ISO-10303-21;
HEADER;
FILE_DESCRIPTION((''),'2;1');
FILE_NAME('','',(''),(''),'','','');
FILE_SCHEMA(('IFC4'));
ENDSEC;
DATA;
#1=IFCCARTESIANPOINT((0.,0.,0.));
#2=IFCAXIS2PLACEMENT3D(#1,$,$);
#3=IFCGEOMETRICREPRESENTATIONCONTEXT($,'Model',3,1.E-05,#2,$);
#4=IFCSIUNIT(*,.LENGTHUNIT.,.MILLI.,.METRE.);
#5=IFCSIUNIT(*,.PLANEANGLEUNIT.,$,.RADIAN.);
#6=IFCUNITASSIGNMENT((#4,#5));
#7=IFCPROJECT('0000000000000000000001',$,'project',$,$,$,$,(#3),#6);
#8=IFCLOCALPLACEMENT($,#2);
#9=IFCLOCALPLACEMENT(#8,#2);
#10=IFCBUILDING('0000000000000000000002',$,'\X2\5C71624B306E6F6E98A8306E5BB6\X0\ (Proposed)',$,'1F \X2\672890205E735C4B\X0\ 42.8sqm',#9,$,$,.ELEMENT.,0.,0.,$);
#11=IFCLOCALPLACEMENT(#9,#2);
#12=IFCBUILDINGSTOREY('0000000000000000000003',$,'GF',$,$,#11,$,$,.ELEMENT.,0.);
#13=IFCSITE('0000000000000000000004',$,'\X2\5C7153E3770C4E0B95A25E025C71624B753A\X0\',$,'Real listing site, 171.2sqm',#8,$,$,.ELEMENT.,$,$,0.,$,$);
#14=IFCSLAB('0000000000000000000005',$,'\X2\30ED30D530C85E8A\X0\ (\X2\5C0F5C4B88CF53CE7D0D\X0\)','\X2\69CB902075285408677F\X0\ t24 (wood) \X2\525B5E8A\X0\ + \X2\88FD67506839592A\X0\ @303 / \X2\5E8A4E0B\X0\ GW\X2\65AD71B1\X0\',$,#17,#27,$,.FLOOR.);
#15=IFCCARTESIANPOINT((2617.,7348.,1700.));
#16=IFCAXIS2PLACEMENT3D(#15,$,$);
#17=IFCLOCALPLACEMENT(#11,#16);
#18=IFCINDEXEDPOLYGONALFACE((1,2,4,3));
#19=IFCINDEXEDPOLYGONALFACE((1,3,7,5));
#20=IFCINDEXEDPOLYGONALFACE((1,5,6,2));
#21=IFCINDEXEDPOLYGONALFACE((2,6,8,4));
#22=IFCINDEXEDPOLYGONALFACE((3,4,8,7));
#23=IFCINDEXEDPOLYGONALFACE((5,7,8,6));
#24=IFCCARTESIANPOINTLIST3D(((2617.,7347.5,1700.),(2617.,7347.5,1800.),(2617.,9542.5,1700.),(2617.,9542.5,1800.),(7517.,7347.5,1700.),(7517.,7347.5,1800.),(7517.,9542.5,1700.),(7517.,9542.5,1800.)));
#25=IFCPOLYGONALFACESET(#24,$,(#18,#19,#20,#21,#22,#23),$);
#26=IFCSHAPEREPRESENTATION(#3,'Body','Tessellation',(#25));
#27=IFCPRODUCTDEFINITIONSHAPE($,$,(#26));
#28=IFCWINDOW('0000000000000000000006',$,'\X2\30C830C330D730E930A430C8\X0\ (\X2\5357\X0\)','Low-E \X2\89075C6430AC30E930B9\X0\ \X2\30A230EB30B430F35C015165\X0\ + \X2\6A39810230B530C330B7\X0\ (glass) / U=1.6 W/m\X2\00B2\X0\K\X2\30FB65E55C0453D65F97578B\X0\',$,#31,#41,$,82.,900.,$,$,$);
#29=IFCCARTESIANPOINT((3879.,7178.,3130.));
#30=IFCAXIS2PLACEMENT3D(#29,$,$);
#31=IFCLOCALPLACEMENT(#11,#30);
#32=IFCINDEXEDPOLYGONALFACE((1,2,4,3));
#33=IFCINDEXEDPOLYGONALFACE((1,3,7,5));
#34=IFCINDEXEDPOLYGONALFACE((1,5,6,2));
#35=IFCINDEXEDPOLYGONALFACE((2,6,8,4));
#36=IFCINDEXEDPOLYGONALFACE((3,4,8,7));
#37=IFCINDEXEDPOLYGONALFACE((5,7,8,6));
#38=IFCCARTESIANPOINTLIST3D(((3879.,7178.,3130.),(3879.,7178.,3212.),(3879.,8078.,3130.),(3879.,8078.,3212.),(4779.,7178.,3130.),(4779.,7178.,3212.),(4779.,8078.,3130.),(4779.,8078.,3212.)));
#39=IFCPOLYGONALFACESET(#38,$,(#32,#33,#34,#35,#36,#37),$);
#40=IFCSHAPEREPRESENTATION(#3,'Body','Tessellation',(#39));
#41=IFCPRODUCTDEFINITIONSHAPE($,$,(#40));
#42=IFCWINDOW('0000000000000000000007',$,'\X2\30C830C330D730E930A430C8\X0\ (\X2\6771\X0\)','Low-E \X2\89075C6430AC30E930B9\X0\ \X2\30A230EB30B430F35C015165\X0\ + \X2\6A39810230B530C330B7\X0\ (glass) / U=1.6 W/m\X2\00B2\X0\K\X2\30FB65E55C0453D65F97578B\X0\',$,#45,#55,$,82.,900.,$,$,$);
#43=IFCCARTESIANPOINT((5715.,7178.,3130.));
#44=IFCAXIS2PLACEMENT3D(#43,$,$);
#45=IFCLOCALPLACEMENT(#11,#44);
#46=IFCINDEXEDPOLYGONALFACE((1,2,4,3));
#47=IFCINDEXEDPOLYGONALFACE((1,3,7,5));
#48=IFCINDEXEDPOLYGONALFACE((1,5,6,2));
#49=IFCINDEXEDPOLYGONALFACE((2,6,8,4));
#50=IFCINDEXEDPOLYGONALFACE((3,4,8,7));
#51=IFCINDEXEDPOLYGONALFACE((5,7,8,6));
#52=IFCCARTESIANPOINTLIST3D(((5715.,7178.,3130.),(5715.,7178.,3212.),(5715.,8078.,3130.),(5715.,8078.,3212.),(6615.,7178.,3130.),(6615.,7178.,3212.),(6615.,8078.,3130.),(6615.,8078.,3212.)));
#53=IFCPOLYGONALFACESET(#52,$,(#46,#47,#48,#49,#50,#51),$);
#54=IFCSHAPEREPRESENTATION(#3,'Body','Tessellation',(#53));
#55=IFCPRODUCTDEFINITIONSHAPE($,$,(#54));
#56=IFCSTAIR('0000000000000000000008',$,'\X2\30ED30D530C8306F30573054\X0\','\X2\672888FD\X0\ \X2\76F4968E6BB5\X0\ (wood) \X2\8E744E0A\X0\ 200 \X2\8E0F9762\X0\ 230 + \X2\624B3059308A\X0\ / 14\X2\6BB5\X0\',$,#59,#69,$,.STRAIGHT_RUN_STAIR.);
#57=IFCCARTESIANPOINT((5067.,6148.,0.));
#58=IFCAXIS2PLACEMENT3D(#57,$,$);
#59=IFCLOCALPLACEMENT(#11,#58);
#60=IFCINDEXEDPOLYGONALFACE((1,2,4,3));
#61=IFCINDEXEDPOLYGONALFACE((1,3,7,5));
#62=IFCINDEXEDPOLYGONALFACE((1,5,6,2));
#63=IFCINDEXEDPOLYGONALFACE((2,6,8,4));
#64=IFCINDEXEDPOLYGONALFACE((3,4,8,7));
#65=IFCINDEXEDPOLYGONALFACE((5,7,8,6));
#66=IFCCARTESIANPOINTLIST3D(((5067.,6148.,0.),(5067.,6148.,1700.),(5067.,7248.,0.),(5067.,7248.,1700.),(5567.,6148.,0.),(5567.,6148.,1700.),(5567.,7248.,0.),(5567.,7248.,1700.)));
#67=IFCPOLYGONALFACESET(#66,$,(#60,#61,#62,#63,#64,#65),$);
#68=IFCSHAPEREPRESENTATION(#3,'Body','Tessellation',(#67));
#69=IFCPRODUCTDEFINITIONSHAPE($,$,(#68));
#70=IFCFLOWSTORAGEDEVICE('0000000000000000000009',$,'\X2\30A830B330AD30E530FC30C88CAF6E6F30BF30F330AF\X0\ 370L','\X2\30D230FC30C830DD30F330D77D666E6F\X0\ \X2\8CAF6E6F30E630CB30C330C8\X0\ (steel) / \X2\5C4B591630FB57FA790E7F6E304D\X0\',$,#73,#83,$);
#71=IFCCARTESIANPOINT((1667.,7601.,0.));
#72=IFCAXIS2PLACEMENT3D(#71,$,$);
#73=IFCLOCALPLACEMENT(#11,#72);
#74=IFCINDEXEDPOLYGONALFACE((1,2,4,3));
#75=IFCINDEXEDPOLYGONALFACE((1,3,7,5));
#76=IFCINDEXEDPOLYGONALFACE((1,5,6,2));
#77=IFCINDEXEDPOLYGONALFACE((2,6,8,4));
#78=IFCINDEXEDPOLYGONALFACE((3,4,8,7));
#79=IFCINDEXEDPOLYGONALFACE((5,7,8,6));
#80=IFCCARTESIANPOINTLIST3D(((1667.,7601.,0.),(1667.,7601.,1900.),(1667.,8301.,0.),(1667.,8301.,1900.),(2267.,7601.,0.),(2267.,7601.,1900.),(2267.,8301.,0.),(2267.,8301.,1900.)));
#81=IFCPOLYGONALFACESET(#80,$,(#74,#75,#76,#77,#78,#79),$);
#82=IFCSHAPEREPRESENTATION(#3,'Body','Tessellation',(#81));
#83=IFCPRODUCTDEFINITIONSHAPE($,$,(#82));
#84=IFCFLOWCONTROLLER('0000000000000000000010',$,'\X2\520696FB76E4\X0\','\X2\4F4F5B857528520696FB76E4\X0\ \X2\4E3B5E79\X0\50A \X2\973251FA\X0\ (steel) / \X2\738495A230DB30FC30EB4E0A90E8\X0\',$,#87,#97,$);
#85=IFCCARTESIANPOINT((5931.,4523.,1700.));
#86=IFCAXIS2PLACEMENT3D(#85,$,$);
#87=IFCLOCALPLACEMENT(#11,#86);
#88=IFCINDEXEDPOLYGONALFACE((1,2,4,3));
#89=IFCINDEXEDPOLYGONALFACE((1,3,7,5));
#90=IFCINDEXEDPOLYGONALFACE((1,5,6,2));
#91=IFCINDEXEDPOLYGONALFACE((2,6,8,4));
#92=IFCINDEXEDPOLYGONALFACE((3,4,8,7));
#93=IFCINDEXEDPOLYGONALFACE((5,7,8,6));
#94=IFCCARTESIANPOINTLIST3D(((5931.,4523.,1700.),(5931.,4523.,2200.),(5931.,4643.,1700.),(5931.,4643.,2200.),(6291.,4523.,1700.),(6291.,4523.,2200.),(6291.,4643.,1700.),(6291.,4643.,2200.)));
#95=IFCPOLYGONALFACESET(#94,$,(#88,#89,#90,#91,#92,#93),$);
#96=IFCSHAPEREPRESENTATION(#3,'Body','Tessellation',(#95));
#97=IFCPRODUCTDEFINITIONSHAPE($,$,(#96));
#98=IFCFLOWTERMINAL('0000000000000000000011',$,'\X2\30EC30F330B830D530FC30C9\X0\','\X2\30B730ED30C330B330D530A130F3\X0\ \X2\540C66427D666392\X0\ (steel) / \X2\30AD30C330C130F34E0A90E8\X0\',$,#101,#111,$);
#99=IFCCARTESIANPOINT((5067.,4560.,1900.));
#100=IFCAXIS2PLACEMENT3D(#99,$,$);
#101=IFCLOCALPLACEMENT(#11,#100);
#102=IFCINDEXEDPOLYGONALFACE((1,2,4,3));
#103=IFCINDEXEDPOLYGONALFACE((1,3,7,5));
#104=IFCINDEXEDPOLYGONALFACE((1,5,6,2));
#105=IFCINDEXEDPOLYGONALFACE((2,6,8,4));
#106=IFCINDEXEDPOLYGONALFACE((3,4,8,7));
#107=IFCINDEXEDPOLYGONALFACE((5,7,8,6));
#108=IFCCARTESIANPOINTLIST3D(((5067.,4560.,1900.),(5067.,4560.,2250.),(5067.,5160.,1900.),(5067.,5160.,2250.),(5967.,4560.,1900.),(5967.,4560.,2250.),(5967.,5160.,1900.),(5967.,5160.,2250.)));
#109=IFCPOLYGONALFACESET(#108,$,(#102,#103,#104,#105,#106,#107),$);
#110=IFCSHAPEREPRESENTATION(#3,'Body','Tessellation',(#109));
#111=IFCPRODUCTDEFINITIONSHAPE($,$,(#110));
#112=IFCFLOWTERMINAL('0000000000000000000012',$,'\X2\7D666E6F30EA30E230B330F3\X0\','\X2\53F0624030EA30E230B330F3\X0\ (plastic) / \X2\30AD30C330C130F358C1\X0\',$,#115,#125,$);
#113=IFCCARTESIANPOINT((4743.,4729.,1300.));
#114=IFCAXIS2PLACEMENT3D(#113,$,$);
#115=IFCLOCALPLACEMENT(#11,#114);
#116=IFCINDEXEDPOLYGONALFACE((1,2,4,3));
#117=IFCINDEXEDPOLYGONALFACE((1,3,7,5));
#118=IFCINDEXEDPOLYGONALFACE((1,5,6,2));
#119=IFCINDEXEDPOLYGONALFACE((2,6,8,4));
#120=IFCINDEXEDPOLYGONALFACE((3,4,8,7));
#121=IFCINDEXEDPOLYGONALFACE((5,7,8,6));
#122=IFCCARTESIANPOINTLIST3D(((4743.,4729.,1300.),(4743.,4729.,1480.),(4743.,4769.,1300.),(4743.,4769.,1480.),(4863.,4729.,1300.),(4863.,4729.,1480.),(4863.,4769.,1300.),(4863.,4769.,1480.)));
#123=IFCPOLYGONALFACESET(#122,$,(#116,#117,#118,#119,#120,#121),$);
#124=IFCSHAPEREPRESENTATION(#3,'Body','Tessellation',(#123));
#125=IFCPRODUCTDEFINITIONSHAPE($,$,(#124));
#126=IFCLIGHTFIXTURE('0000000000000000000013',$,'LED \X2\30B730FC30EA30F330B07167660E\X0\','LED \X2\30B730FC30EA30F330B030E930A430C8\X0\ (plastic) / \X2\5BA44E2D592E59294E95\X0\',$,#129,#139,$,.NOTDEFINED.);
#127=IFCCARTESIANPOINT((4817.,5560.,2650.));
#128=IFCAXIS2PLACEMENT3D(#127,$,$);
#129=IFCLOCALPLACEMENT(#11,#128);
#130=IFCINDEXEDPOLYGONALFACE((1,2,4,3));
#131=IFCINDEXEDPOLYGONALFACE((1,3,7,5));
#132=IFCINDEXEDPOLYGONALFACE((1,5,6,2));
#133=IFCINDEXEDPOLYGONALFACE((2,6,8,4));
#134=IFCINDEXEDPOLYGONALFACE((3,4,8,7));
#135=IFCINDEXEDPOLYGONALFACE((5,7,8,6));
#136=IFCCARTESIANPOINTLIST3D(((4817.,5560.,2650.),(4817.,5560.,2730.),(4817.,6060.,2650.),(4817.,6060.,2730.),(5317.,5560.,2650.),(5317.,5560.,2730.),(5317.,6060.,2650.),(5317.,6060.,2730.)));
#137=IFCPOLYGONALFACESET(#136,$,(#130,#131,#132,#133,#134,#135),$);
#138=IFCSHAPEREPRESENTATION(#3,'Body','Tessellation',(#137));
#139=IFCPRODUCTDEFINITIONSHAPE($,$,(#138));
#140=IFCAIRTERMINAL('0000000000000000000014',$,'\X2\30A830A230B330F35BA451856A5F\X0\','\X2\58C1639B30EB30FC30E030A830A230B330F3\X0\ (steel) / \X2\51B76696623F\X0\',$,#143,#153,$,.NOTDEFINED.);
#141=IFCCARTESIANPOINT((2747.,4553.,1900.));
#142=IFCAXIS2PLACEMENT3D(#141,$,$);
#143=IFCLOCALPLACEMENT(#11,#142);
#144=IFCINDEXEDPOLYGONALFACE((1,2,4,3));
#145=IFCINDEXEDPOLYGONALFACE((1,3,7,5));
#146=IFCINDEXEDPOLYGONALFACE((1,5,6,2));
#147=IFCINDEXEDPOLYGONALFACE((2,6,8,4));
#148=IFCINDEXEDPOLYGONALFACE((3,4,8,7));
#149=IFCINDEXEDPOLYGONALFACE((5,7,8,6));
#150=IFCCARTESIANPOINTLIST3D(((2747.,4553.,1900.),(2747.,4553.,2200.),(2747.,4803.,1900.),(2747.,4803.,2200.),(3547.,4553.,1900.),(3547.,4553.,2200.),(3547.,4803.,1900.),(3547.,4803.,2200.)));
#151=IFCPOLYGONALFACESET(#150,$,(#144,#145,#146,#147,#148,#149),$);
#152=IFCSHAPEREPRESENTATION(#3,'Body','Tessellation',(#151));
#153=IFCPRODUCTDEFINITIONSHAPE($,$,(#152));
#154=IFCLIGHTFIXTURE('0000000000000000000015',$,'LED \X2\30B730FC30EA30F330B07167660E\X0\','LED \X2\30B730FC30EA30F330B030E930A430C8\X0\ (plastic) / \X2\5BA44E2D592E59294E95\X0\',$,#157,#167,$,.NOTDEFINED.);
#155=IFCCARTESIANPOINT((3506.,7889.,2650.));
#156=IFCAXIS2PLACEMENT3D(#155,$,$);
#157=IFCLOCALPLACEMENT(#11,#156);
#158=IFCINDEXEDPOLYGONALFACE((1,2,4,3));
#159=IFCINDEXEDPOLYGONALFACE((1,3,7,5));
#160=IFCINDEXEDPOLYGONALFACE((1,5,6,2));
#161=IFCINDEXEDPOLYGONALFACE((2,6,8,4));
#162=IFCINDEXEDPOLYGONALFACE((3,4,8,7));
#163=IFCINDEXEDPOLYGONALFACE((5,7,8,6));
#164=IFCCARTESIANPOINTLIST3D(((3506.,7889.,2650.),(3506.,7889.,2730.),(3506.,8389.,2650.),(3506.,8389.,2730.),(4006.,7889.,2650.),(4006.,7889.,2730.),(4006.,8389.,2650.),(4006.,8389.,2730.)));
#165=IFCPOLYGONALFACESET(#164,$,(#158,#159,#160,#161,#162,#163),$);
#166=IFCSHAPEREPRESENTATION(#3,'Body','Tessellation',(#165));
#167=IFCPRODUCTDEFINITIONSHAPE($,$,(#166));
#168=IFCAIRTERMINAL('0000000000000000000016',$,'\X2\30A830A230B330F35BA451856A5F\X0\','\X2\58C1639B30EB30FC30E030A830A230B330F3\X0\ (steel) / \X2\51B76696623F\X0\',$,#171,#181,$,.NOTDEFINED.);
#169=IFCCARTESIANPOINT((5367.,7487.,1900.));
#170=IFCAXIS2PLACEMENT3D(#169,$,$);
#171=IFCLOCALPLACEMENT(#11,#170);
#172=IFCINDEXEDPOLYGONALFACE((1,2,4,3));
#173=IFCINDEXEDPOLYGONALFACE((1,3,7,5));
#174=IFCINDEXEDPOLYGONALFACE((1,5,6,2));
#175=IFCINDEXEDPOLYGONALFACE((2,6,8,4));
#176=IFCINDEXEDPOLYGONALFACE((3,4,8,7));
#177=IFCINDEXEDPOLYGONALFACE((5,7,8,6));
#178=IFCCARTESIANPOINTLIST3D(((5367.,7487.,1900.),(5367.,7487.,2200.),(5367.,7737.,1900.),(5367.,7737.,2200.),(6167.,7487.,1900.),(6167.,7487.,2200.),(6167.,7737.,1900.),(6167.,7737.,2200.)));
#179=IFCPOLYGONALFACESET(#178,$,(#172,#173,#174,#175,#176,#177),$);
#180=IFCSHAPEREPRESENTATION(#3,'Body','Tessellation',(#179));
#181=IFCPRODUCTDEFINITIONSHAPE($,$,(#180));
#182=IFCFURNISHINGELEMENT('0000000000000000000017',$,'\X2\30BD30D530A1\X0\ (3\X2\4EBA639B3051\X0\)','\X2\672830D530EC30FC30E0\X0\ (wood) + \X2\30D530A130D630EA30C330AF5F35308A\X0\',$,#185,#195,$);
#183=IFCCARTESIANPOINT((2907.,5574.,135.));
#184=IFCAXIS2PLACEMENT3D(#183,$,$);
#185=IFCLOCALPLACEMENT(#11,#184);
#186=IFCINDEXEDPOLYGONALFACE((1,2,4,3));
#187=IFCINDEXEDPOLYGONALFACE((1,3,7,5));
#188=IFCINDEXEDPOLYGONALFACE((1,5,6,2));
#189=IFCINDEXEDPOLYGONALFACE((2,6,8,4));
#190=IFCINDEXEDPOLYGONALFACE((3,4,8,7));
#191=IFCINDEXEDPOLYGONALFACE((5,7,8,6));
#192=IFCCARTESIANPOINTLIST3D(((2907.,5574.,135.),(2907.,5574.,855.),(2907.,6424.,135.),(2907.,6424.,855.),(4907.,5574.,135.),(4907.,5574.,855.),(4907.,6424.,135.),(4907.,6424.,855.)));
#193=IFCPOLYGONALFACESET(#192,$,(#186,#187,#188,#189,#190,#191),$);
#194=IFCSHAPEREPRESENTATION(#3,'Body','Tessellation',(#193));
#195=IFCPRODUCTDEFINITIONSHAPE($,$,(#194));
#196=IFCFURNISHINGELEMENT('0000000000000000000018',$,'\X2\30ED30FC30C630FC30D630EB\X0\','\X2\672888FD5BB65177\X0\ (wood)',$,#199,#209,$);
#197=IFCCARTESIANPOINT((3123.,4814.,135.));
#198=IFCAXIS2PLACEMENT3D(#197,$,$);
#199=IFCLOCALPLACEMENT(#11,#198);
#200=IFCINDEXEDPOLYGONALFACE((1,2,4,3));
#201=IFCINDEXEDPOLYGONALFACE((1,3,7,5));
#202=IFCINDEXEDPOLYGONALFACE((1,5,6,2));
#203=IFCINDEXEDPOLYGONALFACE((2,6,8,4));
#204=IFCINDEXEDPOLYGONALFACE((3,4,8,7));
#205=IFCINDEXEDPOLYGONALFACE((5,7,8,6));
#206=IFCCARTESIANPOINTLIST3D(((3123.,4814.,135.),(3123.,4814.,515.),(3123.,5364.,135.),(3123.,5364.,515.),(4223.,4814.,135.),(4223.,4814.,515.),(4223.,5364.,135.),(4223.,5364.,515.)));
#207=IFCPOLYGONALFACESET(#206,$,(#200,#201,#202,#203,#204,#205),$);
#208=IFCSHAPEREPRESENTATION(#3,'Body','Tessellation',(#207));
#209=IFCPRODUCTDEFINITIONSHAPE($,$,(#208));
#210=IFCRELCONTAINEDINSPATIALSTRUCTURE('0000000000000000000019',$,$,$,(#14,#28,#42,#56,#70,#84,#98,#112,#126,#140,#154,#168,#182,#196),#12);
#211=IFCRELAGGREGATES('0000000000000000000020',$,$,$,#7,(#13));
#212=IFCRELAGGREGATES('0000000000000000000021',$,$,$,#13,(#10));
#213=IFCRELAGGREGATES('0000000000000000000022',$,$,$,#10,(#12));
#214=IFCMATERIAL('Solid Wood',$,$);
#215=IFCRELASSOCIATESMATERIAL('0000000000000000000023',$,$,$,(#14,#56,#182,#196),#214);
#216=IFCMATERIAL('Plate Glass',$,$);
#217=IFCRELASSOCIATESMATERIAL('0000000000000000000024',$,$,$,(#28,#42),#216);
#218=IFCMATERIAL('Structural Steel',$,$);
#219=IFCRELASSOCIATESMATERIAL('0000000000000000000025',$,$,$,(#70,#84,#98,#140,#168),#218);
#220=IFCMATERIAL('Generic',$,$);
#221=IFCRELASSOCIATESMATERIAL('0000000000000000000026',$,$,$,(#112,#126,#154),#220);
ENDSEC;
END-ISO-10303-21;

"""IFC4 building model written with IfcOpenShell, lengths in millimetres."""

from ifc_helpers import new_model, si_unit, frame, frame_2d, origin, place, context, project, spatial, rectangle, extrude, material, element, save


model = new_model("IFC4")

# Units and contexts
model_context = context("Model", 3, precision=1e-05, world=origin())
ifc_project = project(units=[si_unit("LENGTHUNIT", "METRE", prefix="MILLI"), si_unit("PLANEANGLEUNIT", "RADIAN")], contexts=[model_context])

# Site, building, storey
site_placement = place(None, origin())
site = spatial("IfcSite", under=ifc_project, at=site_placement, Name="山口県下関市山手町", ObjectType="Real listing site, 171.2sqm", CompositionType="ELEMENT", RefElevation=0.0)
building_placement = place(site_placement, origin())
building = spatial("IfcBuilding", under=site, at=building_placement, Name="山手の潮風の家 (Proposed)", ObjectType="1F 木造平屋 42.8sqm", CompositionType="ELEMENT", ElevationOfRefHeight=0.0, ElevationOfTerrain=0.0)
storey_placement = place(building_placement, origin())
storey = spatial("IfcBuildingStorey", under=building, at=storey_placement, Name="GF", CompositionType="ELEMENT", Elevation=0.0)

# Shared definitions
ifc_material_1 = material(Name="Solid Wood")

# Slab
slab_placement = place(storey_placement, frame((2617.0, 7348.0, 1700.0)))
element("IfcSlab", 1, at=slab_placement, inside=storey, material=ifc_material_1, Name="ロフト床 (小屋裏収納)", Description="構造用合板 t24 (wood) 剛床 + 製材根太 @303 / 床下 GW断熱", PredefinedType="FLOOR", context=model_context, shape_type="SweptSolid", body=[
    extrude(rectangle(XDim=4900.0, YDim=2195.0, at=frame_2d((2450.0, 1097.0))), frame((2617.0, 7348.0, 1700.0)), (0.0, 0.0, 1.0), 100.0),
])

# Windows
ifc_material_2 = material(Name="Plate Glass")
window_1_placement = place(storey_placement, frame((3879.0, 7178.0, 3130.0)))
element("IfcWindow", 2, at=window_1_placement, inside=storey, material=ifc_material_2, Name="トップライト (南)", Description="Low-E 複層ガラス アルゴン封入 + 樹脂サッシ (glass) / U=1.6 W/m²K・日射取得型", OverallHeight=82.0, OverallWidth=900.0, context=model_context, shape_type="SweptSolid", body=[
    extrude(rectangle(XDim=900.0, YDim=900.0, at=frame_2d((450.0, 450.0))), frame((3879.0, 7178.0, 3130.0)), (0.0, 0.0, 1.0), 82.0),
])
window_2_placement = place(storey_placement, frame((5715.0, 7178.0, 3130.0)))
element("IfcWindow", 3, at=window_2_placement, inside=storey, material=ifc_material_2, Name="トップライト (東)", Description="Low-E 複層ガラス アルゴン封入 + 樹脂サッシ (glass) / U=1.6 W/m²K・日射取得型", OverallHeight=82.0, OverallWidth=900.0, context=model_context, shape_type="SweptSolid", body=[
    extrude(rectangle(XDim=900.0, YDim=900.0, at=frame_2d((450.0, 450.0))), frame((5715.0, 7178.0, 3130.0)), (0.0, 0.0, 1.0), 82.0),
])

# Stair
stair_placement = place(storey_placement, frame((5067.0, 6148.0, 0.0)))
element("IfcStair", 4, at=stair_placement, inside=storey, material=ifc_material_1, Name="ロフトはしご", Description="木製 直階段 (wood) 蹴上 200 踏面 230 + 手すり / 14段", PredefinedType="STRAIGHT_RUN_STAIR", context=model_context, shape_type="SweptSolid", body=[
    extrude(rectangle(XDim=500.0, YDim=1100.0, at=frame_2d((250.0, 550.0))), frame((5067.0, 6148.0, 0.0)), (0.0, 0.0, 1.0), 1700.0),
])

# Flow storage device
ifc_material_3 = material(Name="Structural Steel")
flow_storage_device_placement = place(storey_placement, frame((1667.0, 7601.0, 0.0)))
element("IfcFlowStorageDevice", 5, at=flow_storage_device_placement, inside=storey, material=ifc_material_3, Name="エコキュート貯湯タンク 370L", Description="ヒートポンプ給湯 貯湯ユニット (steel) / 屋外・基礎置き", context=model_context, shape_type="SweptSolid", body=[
    extrude(rectangle(XDim=600.0, YDim=700.0, at=frame_2d((300.0, 350.0))), frame((1667.0, 7601.0, 0.0)), (0.0, 0.0, 1.0), 1900.0),
])

# Flow controller
flow_controller_placement = place(storey_placement, frame((5931.0, 4523.0, 1700.0)))
element("IfcFlowController", 6, at=flow_controller_placement, inside=storey, material=ifc_material_3, Name="分電盤", Description="住宅用分電盤 主幹50A 露出 (steel) / 玄関ホール上部", context=model_context, shape_type="SweptSolid", body=[
    extrude(rectangle(XDim=360.0, YDim=120.0, at=frame_2d((180.0, 60.0))), frame((5931.0, 4523.0, 1700.0)), (0.0, 0.0, 1.0), 500.0),
])

# Flow terminals
flow_terminal_1_placement = place(storey_placement, frame((5067.0, 4560.0, 1900.0)))
element("IfcFlowTerminal", 7, at=flow_terminal_1_placement, inside=storey, material=ifc_material_3, Name="レンジフード", Description="シロッコファン 同時給排 (steel) / キッチン上部", context=model_context, shape_type="SweptSolid", body=[
    extrude(rectangle(XDim=900.0, YDim=600.0, at=frame_2d((450.0, 300.0))), frame((5067.0, 4560.0, 1900.0)), (0.0, 0.0, 1.0), 350.0),
])
ifc_material_4 = material(Name="Generic")
flow_terminal_2_placement = place(storey_placement, frame((4743.0, 4729.0, 1300.0)))
element("IfcFlowTerminal", 8, at=flow_terminal_2_placement, inside=storey, material=ifc_material_4, Name="給湯リモコン", Description="台所リモコン (plastic) / キッチン壁", context=model_context, shape_type="SweptSolid", body=[
    extrude(rectangle(XDim=120.0, YDim=40.0, at=frame_2d((60.0, 20.0))), frame((4743.0, 4729.0, 1300.0)), (0.0, 0.0, 1.0), 180.0),
])

# Light fixture
light_fixture_1_placement = place(storey_placement, frame((4817.0, 5560.0, 2650.0)))
element("IfcLightFixture", 9, at=light_fixture_1_placement, inside=storey, material=ifc_material_4, Name="LED シーリング照明", Description="LED シーリングライト (plastic) / 室中央天井", PredefinedType="NOTDEFINED", context=model_context, shape_type="SweptSolid", body=[
    extrude(rectangle(XDim=500.0, YDim=500.0, at=frame_2d((250.0, 250.0))), frame((4817.0, 5560.0, 2650.0)), (0.0, 0.0, 1.0), 80.0),
])

# Air terminal
air_terminal_1_placement = place(storey_placement, frame((2747.0, 4553.0, 1900.0)))
element("IfcAirTerminal", 10, at=air_terminal_1_placement, inside=storey, material=ifc_material_3, Name="エアコン室内機", Description="壁掛ルームエアコン (steel) / 冷暖房", PredefinedType="NOTDEFINED", context=model_context, shape_type="SweptSolid", body=[
    extrude(rectangle(XDim=800.0, YDim=250.0, at=frame_2d((400.0, 125.0))), frame((2747.0, 4553.0, 1900.0)), (0.0, 0.0, 1.0), 300.0),
])

# Light fixture
light_fixture_2_placement = place(storey_placement, frame((3506.0, 7889.0, 2650.0)))
element("IfcLightFixture", 11, at=light_fixture_2_placement, inside=storey, material=ifc_material_4, Name="LED シーリング照明", Description="LED シーリングライト (plastic) / 室中央天井", PredefinedType="NOTDEFINED", context=model_context, shape_type="SweptSolid", body=[
    extrude(rectangle(XDim=500.0, YDim=500.0, at=frame_2d((250.0, 250.0))), frame((3506.0, 7889.0, 2650.0)), (0.0, 0.0, 1.0), 80.0),
])

# Air terminal
air_terminal_2_placement = place(storey_placement, frame((5367.0, 7487.0, 1900.0)))
element("IfcAirTerminal", 12, at=air_terminal_2_placement, inside=storey, material=ifc_material_3, Name="エアコン室内機", Description="壁掛ルームエアコン (steel) / 冷暖房", PredefinedType="NOTDEFINED", context=model_context, shape_type="SweptSolid", body=[
    extrude(rectangle(XDim=800.0, YDim=250.0, at=frame_2d((400.0, 125.0))), frame((5367.0, 7487.0, 1900.0)), (0.0, 0.0, 1.0), 300.0),
])

# Furnishing elements
furnishing_1_placement = place(storey_placement, frame((2907.0, 5574.0, 135.0)))
element("IfcFurnishingElement", 13, at=furnishing_1_placement, inside=storey, material=ifc_material_1, Name="ソファ (3人掛け)", Description="木フレーム (wood) + ファブリック張り", context=model_context, shape_type="SweptSolid", body=[
    extrude(rectangle(XDim=2000.0, YDim=850.0, at=frame_2d((1000.0, 425.0))), frame((2907.0, 5574.0, 135.0)), (0.0, 0.0, 1.0), 720.0),
])
furnishing_2_placement = place(storey_placement, frame((3123.0, 4814.0, 135.0)))
element("IfcFurnishingElement", 14, at=furnishing_2_placement, inside=storey, material=ifc_material_1, Name="ローテーブル", Description="木製家具 (wood)", context=model_context, shape_type="SweptSolid", body=[
    extrude(rectangle(XDim=1100.0, YDim=550.0, at=frame_2d((550.0, 275.0))), frame((3123.0, 4814.0, 135.0)), (0.0, 0.0, 1.0), 380.0),
])

save(model, "model.ifc")
